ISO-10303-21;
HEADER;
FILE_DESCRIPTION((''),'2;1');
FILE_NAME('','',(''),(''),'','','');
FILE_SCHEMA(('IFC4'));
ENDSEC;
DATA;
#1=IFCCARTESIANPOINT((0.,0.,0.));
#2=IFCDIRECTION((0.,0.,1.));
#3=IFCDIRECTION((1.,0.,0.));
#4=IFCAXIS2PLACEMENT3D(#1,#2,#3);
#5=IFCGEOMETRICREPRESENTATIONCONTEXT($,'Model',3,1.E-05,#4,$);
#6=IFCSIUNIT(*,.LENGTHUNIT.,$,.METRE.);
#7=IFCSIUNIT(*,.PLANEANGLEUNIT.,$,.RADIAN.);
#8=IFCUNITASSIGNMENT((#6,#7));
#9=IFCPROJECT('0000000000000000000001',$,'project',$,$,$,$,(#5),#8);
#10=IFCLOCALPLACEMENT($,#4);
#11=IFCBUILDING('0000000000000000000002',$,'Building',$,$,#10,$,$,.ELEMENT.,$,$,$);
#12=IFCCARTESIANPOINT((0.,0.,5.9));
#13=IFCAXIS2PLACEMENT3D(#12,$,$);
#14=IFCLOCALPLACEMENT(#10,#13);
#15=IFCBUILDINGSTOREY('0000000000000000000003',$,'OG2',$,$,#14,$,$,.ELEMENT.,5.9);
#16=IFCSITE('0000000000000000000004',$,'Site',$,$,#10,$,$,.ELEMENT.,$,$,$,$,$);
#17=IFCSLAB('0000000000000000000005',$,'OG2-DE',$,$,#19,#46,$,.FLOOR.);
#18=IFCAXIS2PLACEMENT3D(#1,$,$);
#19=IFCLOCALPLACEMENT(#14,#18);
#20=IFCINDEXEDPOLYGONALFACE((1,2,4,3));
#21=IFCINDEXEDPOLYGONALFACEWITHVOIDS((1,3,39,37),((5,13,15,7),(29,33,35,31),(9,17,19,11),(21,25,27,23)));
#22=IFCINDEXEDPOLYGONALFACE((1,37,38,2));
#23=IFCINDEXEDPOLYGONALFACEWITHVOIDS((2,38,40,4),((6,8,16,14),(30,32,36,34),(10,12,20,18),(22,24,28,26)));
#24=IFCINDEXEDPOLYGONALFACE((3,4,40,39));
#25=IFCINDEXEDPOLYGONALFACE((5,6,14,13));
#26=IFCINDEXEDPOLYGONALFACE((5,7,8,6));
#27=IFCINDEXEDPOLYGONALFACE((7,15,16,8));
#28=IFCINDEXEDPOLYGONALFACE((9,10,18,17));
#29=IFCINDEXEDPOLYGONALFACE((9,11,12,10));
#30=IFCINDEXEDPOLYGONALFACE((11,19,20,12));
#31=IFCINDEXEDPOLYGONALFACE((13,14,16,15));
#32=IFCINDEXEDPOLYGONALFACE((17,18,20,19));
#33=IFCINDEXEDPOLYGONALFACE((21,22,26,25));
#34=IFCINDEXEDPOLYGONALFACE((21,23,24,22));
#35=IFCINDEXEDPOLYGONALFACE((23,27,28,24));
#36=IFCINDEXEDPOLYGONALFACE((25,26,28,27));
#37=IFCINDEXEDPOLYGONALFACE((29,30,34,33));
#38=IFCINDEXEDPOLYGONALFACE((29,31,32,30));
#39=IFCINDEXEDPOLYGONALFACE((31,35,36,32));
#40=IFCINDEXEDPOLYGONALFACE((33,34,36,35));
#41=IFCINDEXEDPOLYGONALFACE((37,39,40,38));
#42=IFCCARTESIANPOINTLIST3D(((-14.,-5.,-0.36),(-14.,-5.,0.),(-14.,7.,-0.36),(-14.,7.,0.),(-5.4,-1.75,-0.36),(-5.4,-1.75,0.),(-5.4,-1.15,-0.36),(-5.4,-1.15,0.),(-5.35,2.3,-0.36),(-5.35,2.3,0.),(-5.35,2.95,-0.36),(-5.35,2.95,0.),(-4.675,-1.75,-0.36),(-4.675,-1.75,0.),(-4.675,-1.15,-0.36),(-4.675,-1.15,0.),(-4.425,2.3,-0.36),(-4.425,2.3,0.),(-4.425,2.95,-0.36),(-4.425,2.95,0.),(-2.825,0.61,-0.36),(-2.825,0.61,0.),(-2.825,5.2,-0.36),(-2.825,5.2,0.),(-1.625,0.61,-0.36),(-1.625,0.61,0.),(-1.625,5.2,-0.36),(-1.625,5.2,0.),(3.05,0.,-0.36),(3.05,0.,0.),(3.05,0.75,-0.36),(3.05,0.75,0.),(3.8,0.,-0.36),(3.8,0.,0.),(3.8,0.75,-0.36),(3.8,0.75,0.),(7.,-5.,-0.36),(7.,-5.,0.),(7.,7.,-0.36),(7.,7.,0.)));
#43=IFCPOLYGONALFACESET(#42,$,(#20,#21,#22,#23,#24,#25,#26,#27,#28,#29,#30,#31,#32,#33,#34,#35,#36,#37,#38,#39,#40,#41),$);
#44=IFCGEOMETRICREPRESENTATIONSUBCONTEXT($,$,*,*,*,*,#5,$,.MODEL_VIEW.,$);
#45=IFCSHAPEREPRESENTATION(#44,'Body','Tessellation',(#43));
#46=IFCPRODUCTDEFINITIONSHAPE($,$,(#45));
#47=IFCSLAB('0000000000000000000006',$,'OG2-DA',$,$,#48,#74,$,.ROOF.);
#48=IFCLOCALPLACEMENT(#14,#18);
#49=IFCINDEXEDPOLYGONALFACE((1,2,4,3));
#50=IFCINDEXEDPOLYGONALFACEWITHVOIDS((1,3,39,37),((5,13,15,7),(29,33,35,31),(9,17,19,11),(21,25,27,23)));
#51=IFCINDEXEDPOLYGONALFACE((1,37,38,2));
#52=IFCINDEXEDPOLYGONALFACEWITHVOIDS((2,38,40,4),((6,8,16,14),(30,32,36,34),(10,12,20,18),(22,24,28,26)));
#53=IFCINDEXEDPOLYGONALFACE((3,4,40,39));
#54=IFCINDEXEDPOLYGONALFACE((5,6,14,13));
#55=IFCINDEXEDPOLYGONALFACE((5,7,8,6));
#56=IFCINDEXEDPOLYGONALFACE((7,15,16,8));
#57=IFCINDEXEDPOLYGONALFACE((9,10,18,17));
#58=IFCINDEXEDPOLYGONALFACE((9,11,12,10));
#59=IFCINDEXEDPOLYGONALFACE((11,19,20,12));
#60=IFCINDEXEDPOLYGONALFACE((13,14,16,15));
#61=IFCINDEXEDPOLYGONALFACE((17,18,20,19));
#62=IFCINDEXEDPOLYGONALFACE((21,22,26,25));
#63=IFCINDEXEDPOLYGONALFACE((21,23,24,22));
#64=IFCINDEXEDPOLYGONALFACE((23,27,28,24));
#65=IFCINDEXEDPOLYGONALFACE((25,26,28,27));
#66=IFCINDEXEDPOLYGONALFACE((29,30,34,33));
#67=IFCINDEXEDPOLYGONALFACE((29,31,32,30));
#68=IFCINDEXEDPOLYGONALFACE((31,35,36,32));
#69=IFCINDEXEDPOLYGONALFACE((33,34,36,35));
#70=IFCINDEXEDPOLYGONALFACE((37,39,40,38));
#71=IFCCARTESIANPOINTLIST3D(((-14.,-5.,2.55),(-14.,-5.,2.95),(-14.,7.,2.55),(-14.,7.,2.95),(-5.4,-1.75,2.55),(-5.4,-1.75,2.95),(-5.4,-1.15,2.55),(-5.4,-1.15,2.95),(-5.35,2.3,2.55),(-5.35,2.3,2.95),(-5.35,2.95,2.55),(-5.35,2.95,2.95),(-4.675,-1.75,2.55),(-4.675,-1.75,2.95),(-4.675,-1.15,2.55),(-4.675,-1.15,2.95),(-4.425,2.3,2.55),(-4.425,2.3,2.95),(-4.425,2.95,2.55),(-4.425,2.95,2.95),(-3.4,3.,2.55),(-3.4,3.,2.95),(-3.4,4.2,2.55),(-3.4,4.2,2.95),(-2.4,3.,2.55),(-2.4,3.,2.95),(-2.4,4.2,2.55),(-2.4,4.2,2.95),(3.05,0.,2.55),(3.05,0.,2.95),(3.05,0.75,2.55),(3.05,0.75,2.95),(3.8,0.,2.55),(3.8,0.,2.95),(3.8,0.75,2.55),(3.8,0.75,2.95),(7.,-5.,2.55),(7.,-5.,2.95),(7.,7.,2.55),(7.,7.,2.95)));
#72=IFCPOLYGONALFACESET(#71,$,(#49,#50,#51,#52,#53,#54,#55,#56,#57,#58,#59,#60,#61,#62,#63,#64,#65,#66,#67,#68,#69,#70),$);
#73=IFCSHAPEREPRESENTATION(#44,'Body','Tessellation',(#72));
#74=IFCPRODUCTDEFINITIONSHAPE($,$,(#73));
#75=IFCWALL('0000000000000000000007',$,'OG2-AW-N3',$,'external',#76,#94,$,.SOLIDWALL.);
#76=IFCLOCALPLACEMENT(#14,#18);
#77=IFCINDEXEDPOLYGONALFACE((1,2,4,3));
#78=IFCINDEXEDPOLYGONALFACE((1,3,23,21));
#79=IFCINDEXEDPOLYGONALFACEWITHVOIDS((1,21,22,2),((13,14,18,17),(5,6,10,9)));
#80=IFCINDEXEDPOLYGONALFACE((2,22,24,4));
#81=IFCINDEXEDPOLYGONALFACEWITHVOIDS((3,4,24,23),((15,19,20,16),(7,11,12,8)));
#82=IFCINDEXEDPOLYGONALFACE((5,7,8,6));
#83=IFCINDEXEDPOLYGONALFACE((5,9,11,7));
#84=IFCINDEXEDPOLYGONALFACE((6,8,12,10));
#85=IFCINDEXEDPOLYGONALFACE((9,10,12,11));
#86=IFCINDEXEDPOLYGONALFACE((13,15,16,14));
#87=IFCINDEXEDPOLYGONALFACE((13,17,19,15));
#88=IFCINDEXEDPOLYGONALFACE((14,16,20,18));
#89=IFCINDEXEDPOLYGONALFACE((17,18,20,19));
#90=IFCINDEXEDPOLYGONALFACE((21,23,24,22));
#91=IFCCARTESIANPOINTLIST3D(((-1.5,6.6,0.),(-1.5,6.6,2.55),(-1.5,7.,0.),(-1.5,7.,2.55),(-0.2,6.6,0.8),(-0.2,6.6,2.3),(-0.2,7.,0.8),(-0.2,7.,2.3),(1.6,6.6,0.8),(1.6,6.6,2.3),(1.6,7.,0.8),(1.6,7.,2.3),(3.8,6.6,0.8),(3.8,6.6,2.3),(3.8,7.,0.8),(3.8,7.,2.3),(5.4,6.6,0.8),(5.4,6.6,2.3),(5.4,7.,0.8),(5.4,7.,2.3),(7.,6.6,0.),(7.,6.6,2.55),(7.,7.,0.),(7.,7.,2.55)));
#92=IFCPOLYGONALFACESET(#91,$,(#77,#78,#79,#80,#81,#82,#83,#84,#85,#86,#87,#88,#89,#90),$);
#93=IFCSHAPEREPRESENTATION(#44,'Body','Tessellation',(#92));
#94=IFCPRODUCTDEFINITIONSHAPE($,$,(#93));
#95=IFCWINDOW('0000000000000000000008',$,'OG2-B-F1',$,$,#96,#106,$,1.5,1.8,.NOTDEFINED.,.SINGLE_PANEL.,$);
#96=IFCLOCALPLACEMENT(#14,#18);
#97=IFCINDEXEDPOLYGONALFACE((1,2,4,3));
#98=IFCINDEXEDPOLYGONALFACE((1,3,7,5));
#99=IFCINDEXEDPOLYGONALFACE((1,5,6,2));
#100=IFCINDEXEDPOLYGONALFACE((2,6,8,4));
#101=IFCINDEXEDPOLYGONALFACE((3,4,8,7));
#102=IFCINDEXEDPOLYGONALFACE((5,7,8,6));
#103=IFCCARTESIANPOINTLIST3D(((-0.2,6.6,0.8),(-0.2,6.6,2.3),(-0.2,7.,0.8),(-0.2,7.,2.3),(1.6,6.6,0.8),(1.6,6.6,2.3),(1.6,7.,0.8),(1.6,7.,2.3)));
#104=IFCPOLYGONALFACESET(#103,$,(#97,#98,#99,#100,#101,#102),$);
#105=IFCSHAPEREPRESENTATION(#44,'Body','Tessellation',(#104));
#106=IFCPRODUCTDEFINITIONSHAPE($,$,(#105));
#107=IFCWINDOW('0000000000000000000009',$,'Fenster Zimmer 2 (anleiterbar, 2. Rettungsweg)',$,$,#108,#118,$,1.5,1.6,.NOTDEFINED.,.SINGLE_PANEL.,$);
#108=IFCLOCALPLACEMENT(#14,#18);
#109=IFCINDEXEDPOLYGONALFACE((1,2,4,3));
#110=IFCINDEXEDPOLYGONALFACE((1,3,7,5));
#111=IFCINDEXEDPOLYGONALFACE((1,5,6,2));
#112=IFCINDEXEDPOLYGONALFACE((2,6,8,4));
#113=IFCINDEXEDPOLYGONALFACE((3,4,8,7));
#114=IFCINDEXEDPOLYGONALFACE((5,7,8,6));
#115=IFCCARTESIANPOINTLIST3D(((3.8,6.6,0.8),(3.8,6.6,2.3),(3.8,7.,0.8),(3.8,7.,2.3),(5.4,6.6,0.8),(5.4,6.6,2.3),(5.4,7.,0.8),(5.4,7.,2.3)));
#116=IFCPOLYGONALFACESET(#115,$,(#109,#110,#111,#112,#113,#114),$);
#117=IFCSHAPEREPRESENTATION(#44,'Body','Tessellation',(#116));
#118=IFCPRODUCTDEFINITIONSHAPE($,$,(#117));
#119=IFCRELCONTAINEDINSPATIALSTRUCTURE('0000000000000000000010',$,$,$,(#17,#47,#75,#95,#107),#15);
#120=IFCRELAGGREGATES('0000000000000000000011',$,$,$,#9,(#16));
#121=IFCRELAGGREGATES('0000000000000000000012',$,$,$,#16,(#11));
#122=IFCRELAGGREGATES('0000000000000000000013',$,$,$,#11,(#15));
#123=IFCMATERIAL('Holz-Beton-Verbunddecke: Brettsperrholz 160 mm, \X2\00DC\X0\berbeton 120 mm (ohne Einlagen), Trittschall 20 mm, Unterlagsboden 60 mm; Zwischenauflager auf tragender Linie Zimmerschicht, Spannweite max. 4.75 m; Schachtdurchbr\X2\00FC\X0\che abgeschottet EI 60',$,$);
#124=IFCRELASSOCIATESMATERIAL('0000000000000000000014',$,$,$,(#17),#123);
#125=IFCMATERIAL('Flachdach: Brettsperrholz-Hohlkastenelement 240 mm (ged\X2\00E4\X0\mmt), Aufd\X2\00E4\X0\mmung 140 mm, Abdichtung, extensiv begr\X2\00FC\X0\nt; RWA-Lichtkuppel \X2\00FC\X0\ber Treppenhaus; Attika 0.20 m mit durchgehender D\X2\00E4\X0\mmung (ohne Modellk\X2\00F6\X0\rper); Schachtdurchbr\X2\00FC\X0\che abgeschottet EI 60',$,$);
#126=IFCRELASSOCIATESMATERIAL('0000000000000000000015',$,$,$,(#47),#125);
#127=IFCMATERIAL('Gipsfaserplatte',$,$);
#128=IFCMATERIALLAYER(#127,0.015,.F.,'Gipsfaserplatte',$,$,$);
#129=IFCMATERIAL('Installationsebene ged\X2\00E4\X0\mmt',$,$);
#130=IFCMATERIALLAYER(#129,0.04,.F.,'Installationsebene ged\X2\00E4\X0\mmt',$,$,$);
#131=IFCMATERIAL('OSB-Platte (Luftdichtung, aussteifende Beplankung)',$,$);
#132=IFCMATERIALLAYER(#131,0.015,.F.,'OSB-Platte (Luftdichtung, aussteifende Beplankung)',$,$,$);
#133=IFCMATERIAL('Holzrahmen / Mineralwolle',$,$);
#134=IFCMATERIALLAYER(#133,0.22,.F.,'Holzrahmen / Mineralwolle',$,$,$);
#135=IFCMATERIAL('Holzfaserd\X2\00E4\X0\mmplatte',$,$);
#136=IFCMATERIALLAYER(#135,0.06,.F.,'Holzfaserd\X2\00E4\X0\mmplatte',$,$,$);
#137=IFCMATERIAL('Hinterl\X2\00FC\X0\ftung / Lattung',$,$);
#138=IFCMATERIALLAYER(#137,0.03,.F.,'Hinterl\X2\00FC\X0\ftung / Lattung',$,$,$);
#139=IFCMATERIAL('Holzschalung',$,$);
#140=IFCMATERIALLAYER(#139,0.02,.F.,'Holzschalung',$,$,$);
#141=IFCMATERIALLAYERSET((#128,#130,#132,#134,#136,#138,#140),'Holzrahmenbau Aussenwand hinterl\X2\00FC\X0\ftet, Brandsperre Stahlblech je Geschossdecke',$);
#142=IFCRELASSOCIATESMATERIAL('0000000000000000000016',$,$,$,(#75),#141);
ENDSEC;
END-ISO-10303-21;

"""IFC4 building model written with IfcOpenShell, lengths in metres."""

from ifc_helpers import new_model, si_unit, frame, frame_2d, origin, origin_with_axes, origin_2d, place, context, subcontext, project, spatial, polyline, rectangle, outline, extrude, material, layer, layer_set, element, fill, save


model = new_model("IFC4")

# Units and contexts
model_context = context("Model", 3, precision=1e-05, world=origin_with_axes())
sub_context = subcontext(model_context, None, None, "MODEL_VIEW")
ifc_project = project(units=[si_unit("LENGTHUNIT", "METRE"), si_unit("PLANEANGLEUNIT", "RADIAN")], contexts=[model_context])

# Site, building, storey
placement = place(None, origin_with_axes())
site = spatial("IfcSite", under=ifc_project, at=placement, Name="Site", CompositionType="ELEMENT")
building = spatial("IfcBuilding", under=site, at=placement, Name="Building", CompositionType="ELEMENT")
storey_placement = place(placement, frame((0.0, 0.0, 5.9)))
storey = spatial("IfcBuildingStorey", under=building, at=storey_placement, Name="OG2", CompositionType="ELEMENT", Elevation=5.9)

# Slabs, openings
ifc_material_1 = material(Name="Holz-Beton-Verbunddecke: Brettsperrholz 160 mm, Überbeton 120 mm (ohne Einlagen), Trittschall 20 mm, Unterlagsboden 60 mm; Zwischenauflager auf tragender Linie Zimmerschicht, Spannweite max. 4.75 m; Schachtdurchbrüche abgeschottet EI 60")
slab_1_placement = place(storey_placement, frame((0.0, 0.0, -0.36)))
slab_1 = element("IfcSlab", 1, at=slab_1_placement, inside=storey, material=ifc_material_1, Name="OG2-DE", PredefinedType="FLOOR", context=sub_context, shape_type="SweptSolid", body=[
    extrude(outline(polyline([(-14.0, -5.0), (7.0, -5.0), (7.0, 7.0), (-14.0, 7.0), (-14.0, -5.0)])), origin(), (0.0, 0.0, 1.0), 0.36),
])
opening_1_placement = place(slab_1_placement, frame((-2.225, 2.905, 0.0)))
element("IfcOpeningElement", 2, at=opening_1_placement, cuts=slab_1, PredefinedType="OPENING", context=sub_context, shape_type="SweptSolid", body=[
    extrude(rectangle(XDim=1.2, YDim=4.59, at=origin_2d()), origin(), (0.0, 0.0, 1.0), 0.46),
])
opening_2_placement = place(slab_1_placement, frame((-4.8875, 2.625, 0.0)))
element("IfcOpeningElement", 3, at=opening_2_placement, cuts=slab_1, PredefinedType="OPENING", context=sub_context, shape_type="SweptSolid", body=[
    extrude(rectangle(XDim=0.925, YDim=0.65, at=origin_2d()), origin(), (0.0, 0.0, 1.0), 0.46),
])
opening_3_placement = place(slab_1_placement, frame((3.425, 0.375, 0.0)))
element("IfcOpeningElement", 4, at=opening_3_placement, cuts=slab_1, PredefinedType="OPENING", context=sub_context, shape_type="SweptSolid", body=[
    extrude(rectangle(XDim=0.75, YDim=0.75, at=origin_2d()), origin(), (0.0, 0.0, 1.0), 0.46),
])
opening_4_placement = place(slab_1_placement, frame((-5.0375, -1.45, 0.0)))
element("IfcOpeningElement", 5, at=opening_4_placement, cuts=slab_1, PredefinedType="OPENING", context=sub_context, shape_type="SweptSolid", body=[
    extrude(rectangle(XDim=0.725, YDim=0.6, at=origin_2d()), origin(), (0.0, 0.0, 1.0), 0.46),
])
ifc_material_2 = material(Name="Flachdach: Brettsperrholz-Hohlkastenelement 240 mm (gedämmt), Aufdämmung 140 mm, Abdichtung, extensiv begrünt; RWA-Lichtkuppel über Treppenhaus; Attika 0.20 m mit durchgehender Dämmung (ohne Modellkörper); Schachtdurchbrüche abgeschottet EI 60")
slab_2_placement = place(storey_placement, frame((0.0, 0.0, 2.55)))
slab_2 = element("IfcSlab", 6, at=slab_2_placement, inside=storey, material=ifc_material_2, Name="OG2-DA", PredefinedType="ROOF", context=sub_context, shape_type="SweptSolid", body=[
    extrude(outline(polyline([(-14.0, -5.0), (7.0, -5.0), (7.0, 7.0), (-14.0, 7.0), (-14.0, -5.0)])), origin(), (0.0, 0.0, 1.0), 0.4),
])
opening_5_placement = place(slab_2_placement, frame((-2.9, 3.6, 0.0)))
element("IfcOpeningElement", 7, at=opening_5_placement, cuts=slab_2, PredefinedType="OPENING", context=sub_context, shape_type="SweptSolid", body=[
    extrude(rectangle(XDim=1.0, YDim=1.2, at=origin_2d()), origin(), (0.0, 0.0, 1.0), 0.5),
])
opening_6_placement = place(slab_2_placement, frame((-4.8875, 2.625, 0.0)))
element("IfcOpeningElement", 8, at=opening_6_placement, cuts=slab_2, PredefinedType="OPENING", context=sub_context, shape_type="SweptSolid", body=[
    extrude(rectangle(XDim=0.925, YDim=0.65, at=origin_2d()), origin(), (0.0, 0.0, 1.0), 0.5),
])
opening_7_placement = place(slab_2_placement, frame((3.425, 0.375, 0.0)))
element("IfcOpeningElement", 9, at=opening_7_placement, cuts=slab_2, PredefinedType="OPENING", context=sub_context, shape_type="SweptSolid", body=[
    extrude(rectangle(XDim=0.75, YDim=0.75, at=origin_2d()), origin(), (0.0, 0.0, 1.0), 0.5),
])
opening_8_placement = place(slab_2_placement, frame((-5.0375, -1.45, 0.0)))
element("IfcOpeningElement", 10, at=opening_8_placement, cuts=slab_2, PredefinedType="OPENING", context=sub_context, shape_type="SweptSolid", body=[
    extrude(rectangle(XDim=0.725, YDim=0.6, at=origin_2d()), origin(), (0.0, 0.0, 1.0), 0.5),
])

# Wall, openings, windows
ifc_material_3 = material(Name="Gipsfaserplatte")
ifc_layer_1 = layer(ifc_material_3, 0.015, ventilated=False, Name="Gipsfaserplatte")
ifc_material_4 = material(Name="Installationsebene gedämmt")
ifc_layer_2 = layer(ifc_material_4, 0.04, ventilated=False, Name="Installationsebene gedämmt")
ifc_material_5 = material(Name="OSB-Platte (Luftdichtung, aussteifende Beplankung)")
ifc_layer_3 = layer(ifc_material_5, 0.015, ventilated=False, Name="OSB-Platte (Luftdichtung, aussteifende Beplankung)")
ifc_material_6 = material(Name="Holzrahmen / Mineralwolle")
ifc_layer_4 = layer(ifc_material_6, 0.22, ventilated=False, Name="Holzrahmen / Mineralwolle")
ifc_material_7 = material(Name="Holzfaserdämmplatte")
ifc_layer_5 = layer(ifc_material_7, 0.06, ventilated=False, Name="Holzfaserdämmplatte")
ifc_material_8 = material(Name="Hinterlüftung / Lattung")
ifc_layer_6 = layer(ifc_material_8, 0.03, ventilated=False, Name="Hinterlüftung / Lattung")
ifc_material_9 = material(Name="Holzschalung")
ifc_layer_7 = layer(ifc_material_9, 0.02, ventilated=False, Name="Holzschalung")
ifc_layer_set_1 = layer_set([ifc_layer_1, ifc_layer_2, ifc_layer_3, ifc_layer_4, ifc_layer_5, ifc_layer_6, ifc_layer_7], Name="Holzrahmenbau Aussenwand hinterlüftet, Brandsperre Stahlblech je Geschossdecke")
wall_1_placement = place(storey_placement, frame((-1.5, 6.8, 0.0), z_axis=(0.0, 0.0, 1.0), x_axis=(1.0, 0.0, 0.0)))
wall_1 = element("IfcWall", 11, at=wall_1_placement, inside=storey, material=ifc_layer_set_1, Name="OG2-AW-N3", ObjectType="external", PredefinedType="SOLIDWALL", context=sub_context, shape_type="SweptSolid", body=[
    extrude(rectangle(XDim=8.5, YDim=0.4, at=frame_2d((4.25, 0.0))), origin(), (0.0, 0.0, 1.0), 2.55),
])
opening_9_placement = place(wall_1_placement, frame((2.2, 0.25, 0.8), z_axis=(0.0, -1.0, 0.0), x_axis=(1.0, 0.0, 0.0)))
opening_9 = element("IfcOpeningElement", 12, at=opening_9_placement, cuts=wall_1, PredefinedType="OPENING", context=sub_context, shape_type="SweptSolid", body=[
    extrude(rectangle(XDim=1.8, YDim=1.5, at=frame_2d((0.0, 0.75))), origin(), (0.0, 0.0, 1.0), 0.5),
])
opening_10_placement = place(wall_1_placement, frame((6.1, 0.25, 0.8), z_axis=(0.0, -1.0, 0.0), x_axis=(1.0, 0.0, 0.0)))
opening_10 = element("IfcOpeningElement", 13, at=opening_10_placement, cuts=wall_1, PredefinedType="OPENING", context=sub_context, shape_type="SweptSolid", body=[
    extrude(rectangle(XDim=1.6, YDim=1.5, at=frame_2d((0.0, 0.75))), origin(), (0.0, 0.0, 1.0), 0.5),
])
window_1_placement = place(wall_1_placement, frame((2.2, 0.2, 0.8), z_axis=(0.0, -1.0, 0.0), x_axis=(1.0, 0.0, 0.0)))
window_1 = element("IfcWindow", 14, at=window_1_placement, inside=storey, Name="OG2-B-F1", OverallHeight=1.5, OverallWidth=1.8, PartitioningType="SINGLE_PANEL", PredefinedType="NOTDEFINED", context=sub_context, shape_type="SweptSolid", body=[
    extrude(rectangle(XDim=1.8, YDim=1.5, at=frame_2d((0.0, 0.75))), origin(), (0.0, 0.0, 1.0), 0.4),
])
fill(opening_9, window_1)
window_2_placement = place(wall_1_placement, frame((6.1, 0.2, 0.8), z_axis=(0.0, -1.0, 0.0), x_axis=(1.0, 0.0, 0.0)))
window_2 = element("IfcWindow", 15, at=window_2_placement, inside=storey, Name="Fenster Zimmer 2 (anleiterbar, 2. Rettungsweg)", OverallHeight=1.5, OverallWidth=1.6, PartitioningType="SINGLE_PANEL", PredefinedType="NOTDEFINED", context=sub_context, shape_type="SweptSolid", body=[
    extrude(rectangle(XDim=1.6, YDim=1.5, at=frame_2d((0.0, 0.75))), origin(), (0.0, 0.0, 1.0), 0.4),
])
fill(opening_10, window_2)

save(model, "model.ifc")
